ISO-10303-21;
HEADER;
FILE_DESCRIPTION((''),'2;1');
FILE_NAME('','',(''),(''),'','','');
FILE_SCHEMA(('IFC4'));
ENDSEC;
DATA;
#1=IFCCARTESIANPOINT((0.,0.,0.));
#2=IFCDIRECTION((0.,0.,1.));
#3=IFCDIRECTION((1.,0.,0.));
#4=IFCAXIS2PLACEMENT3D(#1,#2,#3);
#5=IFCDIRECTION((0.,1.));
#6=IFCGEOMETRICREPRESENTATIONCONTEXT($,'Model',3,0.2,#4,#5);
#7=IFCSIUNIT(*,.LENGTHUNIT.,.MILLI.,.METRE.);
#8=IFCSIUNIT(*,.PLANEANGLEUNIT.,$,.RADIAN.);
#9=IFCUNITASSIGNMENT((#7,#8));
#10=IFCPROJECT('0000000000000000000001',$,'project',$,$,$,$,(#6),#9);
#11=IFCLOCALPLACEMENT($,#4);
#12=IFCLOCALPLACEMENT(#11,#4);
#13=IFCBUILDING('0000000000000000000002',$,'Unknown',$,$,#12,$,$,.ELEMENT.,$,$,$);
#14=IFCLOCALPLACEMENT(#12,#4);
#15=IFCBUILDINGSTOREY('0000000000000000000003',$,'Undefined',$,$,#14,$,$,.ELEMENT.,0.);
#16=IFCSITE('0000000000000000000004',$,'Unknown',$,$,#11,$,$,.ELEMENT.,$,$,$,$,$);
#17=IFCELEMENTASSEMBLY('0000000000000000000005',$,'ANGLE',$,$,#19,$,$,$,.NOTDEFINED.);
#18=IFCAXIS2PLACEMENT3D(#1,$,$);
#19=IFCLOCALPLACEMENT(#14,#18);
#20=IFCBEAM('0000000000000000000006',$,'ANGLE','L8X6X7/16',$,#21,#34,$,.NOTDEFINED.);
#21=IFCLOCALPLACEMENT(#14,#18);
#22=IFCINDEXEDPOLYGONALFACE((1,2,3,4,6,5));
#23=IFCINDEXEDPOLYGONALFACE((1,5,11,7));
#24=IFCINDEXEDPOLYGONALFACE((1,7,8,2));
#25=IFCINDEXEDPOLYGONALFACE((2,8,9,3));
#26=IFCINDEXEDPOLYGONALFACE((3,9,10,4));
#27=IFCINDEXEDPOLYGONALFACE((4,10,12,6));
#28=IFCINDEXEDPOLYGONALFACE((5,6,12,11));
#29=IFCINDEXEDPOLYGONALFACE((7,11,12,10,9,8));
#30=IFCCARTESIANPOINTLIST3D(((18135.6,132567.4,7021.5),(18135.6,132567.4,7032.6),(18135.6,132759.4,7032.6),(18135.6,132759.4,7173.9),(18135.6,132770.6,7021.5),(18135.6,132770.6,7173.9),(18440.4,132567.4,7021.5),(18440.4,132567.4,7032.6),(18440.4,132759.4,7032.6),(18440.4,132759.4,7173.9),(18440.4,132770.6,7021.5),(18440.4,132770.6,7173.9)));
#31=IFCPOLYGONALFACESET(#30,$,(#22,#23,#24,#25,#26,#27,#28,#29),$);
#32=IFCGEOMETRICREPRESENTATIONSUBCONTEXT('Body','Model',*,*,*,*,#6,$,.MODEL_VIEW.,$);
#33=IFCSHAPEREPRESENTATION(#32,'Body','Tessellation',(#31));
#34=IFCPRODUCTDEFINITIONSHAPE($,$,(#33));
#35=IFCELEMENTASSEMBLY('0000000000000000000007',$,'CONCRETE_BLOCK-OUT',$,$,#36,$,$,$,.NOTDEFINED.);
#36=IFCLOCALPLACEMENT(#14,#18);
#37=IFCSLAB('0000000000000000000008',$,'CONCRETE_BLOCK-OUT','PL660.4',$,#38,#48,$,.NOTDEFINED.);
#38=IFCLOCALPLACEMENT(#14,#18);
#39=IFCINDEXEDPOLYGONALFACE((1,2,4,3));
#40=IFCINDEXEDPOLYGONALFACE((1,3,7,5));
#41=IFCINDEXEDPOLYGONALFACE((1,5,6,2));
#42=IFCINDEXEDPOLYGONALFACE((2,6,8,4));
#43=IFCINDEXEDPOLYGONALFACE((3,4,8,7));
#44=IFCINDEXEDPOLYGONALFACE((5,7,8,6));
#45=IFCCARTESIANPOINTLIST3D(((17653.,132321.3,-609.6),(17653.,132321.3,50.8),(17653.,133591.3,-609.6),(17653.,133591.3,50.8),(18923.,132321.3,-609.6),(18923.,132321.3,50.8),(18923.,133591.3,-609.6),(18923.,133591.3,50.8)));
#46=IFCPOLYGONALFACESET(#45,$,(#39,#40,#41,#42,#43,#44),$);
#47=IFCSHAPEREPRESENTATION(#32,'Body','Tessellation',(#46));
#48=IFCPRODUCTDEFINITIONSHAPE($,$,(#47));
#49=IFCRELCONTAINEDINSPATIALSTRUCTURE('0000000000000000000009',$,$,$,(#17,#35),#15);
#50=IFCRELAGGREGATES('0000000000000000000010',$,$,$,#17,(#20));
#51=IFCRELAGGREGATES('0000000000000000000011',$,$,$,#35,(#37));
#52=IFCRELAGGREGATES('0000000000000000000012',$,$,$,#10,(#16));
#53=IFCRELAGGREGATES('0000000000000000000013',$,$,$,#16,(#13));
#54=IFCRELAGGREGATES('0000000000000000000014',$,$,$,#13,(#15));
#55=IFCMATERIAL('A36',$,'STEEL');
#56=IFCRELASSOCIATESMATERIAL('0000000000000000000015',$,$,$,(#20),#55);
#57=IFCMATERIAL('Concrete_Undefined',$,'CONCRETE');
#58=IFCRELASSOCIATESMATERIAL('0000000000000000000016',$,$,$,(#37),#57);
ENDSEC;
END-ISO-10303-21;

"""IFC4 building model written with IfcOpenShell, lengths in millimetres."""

from ifc_helpers import new_model, si_unit, direction, frame, origin_with_axes, place, context, subcontext, project, spatial, line, indexed_curve, outline, extrude, material, element, aggregate, save


model = new_model("IFC4")

# Units and contexts
model_context = context("Model", 3, precision=0.2, world=origin_with_axes(), true_north=direction((0.0, 1.0)))
body_context = subcontext(model_context, "Body", "Model", "MODEL_VIEW")
ifc_project = project(units=[si_unit("LENGTHUNIT", "METRE", prefix="MILLI"), si_unit("PLANEANGLEUNIT", "RADIAN")], contexts=[model_context])

# Site, building, storey
site_placement = place(None, origin_with_axes())
site = spatial("IfcSite", under=ifc_project, at=site_placement, Name="Unknown", CompositionType="ELEMENT")
building_placement = place(site_placement, origin_with_axes())
building = spatial("IfcBuilding", under=site, at=building_placement, Name="Unknown", CompositionType="ELEMENT")
storey_placement = place(building_placement, origin_with_axes())
storey = spatial("IfcBuildingStorey", under=building, at=storey_placement, Name="Undefined", CompositionType="ELEMENT", Elevation=0.0)

# Shared definitions
ifc_material_1 = material(Name="A36", Category="STEEL")

# Element assembly, beam
assembly_1_placement = place(storey_placement, frame((18440.4, 132669.0, 7097.7), z_axis=(0.0, 0.0, 1.0), x_axis=(-1.0, 0.000019, 0.0)))
assembly_1 = element("IfcElementAssembly", 1, at=assembly_1_placement, inside=storey, Name="ANGLE", PredefinedType="NOTDEFINED")
beam_1_placement = place(assembly_1_placement, origin_with_axes())
beam_1 = element("IfcBeam", 2, at=beam_1_placement, material=ifc_material_1, Name="ANGLE", Description="L8X6X7/16", PredefinedType="NOTDEFINED", context=body_context, shape_type="SolidModel", body=[
    extrude(outline(indexed_curve([(-76.2, -101.6), (76.2, -101.6), (76.2, -90.5), (-65.1, -90.5), (-65.1, 101.6), (-76.2, 101.6)], segments=[line(1, 2, 3, 4, 5, 6, 1)])), frame((0.0, 0.0, 0.0), z_axis=(-1.0, 0.0, 0.0), x_axis=(0.0, 0.0, 1.0)), (0.0, 0.0, -1.0), 304.8),
])
aggregate(assembly_1, [beam_1])

# Element assembly, slab
assembly_2_placement = place(storey_placement, frame((18923.0, 133591.3, -279.4), z_axis=(0.0, 0.0, 1.0), x_axis=(-1.0, 0.0, 0.0)))
assembly_2 = element("IfcElementAssembly", 3, at=assembly_2_placement, inside=storey, Name="CONCRETE_BLOCK-OUT", PredefinedType="NOTDEFINED")
ifc_material_2 = material(Name="Concrete_Undefined", Category="CONCRETE")
slab_placement = place(assembly_2_placement, origin_with_axes())
slab = element("IfcSlab", 4, at=slab_placement, material=ifc_material_2, Name="CONCRETE_BLOCK-OUT", Description="PL660.4", PredefinedType="NOTDEFINED", context=body_context, shape_type="SolidModel", body=[
    extrude(outline(indexed_curve([(0.0, 0.0), (1270.0, 0.0), (1270.0, 1270.0), (0.0, 1270.0)], segments=[line(1, 2, 3, 4, 1)])), frame((0.0, 0.0, 330.2), z_axis=(0.0, 0.0, 1.0), x_axis=(1.0, 0.0, 0.0)), (0.0, 0.0, -1.0), 660.4),
])
aggregate(assembly_2, [slab])

save(model, "model.ifc")
